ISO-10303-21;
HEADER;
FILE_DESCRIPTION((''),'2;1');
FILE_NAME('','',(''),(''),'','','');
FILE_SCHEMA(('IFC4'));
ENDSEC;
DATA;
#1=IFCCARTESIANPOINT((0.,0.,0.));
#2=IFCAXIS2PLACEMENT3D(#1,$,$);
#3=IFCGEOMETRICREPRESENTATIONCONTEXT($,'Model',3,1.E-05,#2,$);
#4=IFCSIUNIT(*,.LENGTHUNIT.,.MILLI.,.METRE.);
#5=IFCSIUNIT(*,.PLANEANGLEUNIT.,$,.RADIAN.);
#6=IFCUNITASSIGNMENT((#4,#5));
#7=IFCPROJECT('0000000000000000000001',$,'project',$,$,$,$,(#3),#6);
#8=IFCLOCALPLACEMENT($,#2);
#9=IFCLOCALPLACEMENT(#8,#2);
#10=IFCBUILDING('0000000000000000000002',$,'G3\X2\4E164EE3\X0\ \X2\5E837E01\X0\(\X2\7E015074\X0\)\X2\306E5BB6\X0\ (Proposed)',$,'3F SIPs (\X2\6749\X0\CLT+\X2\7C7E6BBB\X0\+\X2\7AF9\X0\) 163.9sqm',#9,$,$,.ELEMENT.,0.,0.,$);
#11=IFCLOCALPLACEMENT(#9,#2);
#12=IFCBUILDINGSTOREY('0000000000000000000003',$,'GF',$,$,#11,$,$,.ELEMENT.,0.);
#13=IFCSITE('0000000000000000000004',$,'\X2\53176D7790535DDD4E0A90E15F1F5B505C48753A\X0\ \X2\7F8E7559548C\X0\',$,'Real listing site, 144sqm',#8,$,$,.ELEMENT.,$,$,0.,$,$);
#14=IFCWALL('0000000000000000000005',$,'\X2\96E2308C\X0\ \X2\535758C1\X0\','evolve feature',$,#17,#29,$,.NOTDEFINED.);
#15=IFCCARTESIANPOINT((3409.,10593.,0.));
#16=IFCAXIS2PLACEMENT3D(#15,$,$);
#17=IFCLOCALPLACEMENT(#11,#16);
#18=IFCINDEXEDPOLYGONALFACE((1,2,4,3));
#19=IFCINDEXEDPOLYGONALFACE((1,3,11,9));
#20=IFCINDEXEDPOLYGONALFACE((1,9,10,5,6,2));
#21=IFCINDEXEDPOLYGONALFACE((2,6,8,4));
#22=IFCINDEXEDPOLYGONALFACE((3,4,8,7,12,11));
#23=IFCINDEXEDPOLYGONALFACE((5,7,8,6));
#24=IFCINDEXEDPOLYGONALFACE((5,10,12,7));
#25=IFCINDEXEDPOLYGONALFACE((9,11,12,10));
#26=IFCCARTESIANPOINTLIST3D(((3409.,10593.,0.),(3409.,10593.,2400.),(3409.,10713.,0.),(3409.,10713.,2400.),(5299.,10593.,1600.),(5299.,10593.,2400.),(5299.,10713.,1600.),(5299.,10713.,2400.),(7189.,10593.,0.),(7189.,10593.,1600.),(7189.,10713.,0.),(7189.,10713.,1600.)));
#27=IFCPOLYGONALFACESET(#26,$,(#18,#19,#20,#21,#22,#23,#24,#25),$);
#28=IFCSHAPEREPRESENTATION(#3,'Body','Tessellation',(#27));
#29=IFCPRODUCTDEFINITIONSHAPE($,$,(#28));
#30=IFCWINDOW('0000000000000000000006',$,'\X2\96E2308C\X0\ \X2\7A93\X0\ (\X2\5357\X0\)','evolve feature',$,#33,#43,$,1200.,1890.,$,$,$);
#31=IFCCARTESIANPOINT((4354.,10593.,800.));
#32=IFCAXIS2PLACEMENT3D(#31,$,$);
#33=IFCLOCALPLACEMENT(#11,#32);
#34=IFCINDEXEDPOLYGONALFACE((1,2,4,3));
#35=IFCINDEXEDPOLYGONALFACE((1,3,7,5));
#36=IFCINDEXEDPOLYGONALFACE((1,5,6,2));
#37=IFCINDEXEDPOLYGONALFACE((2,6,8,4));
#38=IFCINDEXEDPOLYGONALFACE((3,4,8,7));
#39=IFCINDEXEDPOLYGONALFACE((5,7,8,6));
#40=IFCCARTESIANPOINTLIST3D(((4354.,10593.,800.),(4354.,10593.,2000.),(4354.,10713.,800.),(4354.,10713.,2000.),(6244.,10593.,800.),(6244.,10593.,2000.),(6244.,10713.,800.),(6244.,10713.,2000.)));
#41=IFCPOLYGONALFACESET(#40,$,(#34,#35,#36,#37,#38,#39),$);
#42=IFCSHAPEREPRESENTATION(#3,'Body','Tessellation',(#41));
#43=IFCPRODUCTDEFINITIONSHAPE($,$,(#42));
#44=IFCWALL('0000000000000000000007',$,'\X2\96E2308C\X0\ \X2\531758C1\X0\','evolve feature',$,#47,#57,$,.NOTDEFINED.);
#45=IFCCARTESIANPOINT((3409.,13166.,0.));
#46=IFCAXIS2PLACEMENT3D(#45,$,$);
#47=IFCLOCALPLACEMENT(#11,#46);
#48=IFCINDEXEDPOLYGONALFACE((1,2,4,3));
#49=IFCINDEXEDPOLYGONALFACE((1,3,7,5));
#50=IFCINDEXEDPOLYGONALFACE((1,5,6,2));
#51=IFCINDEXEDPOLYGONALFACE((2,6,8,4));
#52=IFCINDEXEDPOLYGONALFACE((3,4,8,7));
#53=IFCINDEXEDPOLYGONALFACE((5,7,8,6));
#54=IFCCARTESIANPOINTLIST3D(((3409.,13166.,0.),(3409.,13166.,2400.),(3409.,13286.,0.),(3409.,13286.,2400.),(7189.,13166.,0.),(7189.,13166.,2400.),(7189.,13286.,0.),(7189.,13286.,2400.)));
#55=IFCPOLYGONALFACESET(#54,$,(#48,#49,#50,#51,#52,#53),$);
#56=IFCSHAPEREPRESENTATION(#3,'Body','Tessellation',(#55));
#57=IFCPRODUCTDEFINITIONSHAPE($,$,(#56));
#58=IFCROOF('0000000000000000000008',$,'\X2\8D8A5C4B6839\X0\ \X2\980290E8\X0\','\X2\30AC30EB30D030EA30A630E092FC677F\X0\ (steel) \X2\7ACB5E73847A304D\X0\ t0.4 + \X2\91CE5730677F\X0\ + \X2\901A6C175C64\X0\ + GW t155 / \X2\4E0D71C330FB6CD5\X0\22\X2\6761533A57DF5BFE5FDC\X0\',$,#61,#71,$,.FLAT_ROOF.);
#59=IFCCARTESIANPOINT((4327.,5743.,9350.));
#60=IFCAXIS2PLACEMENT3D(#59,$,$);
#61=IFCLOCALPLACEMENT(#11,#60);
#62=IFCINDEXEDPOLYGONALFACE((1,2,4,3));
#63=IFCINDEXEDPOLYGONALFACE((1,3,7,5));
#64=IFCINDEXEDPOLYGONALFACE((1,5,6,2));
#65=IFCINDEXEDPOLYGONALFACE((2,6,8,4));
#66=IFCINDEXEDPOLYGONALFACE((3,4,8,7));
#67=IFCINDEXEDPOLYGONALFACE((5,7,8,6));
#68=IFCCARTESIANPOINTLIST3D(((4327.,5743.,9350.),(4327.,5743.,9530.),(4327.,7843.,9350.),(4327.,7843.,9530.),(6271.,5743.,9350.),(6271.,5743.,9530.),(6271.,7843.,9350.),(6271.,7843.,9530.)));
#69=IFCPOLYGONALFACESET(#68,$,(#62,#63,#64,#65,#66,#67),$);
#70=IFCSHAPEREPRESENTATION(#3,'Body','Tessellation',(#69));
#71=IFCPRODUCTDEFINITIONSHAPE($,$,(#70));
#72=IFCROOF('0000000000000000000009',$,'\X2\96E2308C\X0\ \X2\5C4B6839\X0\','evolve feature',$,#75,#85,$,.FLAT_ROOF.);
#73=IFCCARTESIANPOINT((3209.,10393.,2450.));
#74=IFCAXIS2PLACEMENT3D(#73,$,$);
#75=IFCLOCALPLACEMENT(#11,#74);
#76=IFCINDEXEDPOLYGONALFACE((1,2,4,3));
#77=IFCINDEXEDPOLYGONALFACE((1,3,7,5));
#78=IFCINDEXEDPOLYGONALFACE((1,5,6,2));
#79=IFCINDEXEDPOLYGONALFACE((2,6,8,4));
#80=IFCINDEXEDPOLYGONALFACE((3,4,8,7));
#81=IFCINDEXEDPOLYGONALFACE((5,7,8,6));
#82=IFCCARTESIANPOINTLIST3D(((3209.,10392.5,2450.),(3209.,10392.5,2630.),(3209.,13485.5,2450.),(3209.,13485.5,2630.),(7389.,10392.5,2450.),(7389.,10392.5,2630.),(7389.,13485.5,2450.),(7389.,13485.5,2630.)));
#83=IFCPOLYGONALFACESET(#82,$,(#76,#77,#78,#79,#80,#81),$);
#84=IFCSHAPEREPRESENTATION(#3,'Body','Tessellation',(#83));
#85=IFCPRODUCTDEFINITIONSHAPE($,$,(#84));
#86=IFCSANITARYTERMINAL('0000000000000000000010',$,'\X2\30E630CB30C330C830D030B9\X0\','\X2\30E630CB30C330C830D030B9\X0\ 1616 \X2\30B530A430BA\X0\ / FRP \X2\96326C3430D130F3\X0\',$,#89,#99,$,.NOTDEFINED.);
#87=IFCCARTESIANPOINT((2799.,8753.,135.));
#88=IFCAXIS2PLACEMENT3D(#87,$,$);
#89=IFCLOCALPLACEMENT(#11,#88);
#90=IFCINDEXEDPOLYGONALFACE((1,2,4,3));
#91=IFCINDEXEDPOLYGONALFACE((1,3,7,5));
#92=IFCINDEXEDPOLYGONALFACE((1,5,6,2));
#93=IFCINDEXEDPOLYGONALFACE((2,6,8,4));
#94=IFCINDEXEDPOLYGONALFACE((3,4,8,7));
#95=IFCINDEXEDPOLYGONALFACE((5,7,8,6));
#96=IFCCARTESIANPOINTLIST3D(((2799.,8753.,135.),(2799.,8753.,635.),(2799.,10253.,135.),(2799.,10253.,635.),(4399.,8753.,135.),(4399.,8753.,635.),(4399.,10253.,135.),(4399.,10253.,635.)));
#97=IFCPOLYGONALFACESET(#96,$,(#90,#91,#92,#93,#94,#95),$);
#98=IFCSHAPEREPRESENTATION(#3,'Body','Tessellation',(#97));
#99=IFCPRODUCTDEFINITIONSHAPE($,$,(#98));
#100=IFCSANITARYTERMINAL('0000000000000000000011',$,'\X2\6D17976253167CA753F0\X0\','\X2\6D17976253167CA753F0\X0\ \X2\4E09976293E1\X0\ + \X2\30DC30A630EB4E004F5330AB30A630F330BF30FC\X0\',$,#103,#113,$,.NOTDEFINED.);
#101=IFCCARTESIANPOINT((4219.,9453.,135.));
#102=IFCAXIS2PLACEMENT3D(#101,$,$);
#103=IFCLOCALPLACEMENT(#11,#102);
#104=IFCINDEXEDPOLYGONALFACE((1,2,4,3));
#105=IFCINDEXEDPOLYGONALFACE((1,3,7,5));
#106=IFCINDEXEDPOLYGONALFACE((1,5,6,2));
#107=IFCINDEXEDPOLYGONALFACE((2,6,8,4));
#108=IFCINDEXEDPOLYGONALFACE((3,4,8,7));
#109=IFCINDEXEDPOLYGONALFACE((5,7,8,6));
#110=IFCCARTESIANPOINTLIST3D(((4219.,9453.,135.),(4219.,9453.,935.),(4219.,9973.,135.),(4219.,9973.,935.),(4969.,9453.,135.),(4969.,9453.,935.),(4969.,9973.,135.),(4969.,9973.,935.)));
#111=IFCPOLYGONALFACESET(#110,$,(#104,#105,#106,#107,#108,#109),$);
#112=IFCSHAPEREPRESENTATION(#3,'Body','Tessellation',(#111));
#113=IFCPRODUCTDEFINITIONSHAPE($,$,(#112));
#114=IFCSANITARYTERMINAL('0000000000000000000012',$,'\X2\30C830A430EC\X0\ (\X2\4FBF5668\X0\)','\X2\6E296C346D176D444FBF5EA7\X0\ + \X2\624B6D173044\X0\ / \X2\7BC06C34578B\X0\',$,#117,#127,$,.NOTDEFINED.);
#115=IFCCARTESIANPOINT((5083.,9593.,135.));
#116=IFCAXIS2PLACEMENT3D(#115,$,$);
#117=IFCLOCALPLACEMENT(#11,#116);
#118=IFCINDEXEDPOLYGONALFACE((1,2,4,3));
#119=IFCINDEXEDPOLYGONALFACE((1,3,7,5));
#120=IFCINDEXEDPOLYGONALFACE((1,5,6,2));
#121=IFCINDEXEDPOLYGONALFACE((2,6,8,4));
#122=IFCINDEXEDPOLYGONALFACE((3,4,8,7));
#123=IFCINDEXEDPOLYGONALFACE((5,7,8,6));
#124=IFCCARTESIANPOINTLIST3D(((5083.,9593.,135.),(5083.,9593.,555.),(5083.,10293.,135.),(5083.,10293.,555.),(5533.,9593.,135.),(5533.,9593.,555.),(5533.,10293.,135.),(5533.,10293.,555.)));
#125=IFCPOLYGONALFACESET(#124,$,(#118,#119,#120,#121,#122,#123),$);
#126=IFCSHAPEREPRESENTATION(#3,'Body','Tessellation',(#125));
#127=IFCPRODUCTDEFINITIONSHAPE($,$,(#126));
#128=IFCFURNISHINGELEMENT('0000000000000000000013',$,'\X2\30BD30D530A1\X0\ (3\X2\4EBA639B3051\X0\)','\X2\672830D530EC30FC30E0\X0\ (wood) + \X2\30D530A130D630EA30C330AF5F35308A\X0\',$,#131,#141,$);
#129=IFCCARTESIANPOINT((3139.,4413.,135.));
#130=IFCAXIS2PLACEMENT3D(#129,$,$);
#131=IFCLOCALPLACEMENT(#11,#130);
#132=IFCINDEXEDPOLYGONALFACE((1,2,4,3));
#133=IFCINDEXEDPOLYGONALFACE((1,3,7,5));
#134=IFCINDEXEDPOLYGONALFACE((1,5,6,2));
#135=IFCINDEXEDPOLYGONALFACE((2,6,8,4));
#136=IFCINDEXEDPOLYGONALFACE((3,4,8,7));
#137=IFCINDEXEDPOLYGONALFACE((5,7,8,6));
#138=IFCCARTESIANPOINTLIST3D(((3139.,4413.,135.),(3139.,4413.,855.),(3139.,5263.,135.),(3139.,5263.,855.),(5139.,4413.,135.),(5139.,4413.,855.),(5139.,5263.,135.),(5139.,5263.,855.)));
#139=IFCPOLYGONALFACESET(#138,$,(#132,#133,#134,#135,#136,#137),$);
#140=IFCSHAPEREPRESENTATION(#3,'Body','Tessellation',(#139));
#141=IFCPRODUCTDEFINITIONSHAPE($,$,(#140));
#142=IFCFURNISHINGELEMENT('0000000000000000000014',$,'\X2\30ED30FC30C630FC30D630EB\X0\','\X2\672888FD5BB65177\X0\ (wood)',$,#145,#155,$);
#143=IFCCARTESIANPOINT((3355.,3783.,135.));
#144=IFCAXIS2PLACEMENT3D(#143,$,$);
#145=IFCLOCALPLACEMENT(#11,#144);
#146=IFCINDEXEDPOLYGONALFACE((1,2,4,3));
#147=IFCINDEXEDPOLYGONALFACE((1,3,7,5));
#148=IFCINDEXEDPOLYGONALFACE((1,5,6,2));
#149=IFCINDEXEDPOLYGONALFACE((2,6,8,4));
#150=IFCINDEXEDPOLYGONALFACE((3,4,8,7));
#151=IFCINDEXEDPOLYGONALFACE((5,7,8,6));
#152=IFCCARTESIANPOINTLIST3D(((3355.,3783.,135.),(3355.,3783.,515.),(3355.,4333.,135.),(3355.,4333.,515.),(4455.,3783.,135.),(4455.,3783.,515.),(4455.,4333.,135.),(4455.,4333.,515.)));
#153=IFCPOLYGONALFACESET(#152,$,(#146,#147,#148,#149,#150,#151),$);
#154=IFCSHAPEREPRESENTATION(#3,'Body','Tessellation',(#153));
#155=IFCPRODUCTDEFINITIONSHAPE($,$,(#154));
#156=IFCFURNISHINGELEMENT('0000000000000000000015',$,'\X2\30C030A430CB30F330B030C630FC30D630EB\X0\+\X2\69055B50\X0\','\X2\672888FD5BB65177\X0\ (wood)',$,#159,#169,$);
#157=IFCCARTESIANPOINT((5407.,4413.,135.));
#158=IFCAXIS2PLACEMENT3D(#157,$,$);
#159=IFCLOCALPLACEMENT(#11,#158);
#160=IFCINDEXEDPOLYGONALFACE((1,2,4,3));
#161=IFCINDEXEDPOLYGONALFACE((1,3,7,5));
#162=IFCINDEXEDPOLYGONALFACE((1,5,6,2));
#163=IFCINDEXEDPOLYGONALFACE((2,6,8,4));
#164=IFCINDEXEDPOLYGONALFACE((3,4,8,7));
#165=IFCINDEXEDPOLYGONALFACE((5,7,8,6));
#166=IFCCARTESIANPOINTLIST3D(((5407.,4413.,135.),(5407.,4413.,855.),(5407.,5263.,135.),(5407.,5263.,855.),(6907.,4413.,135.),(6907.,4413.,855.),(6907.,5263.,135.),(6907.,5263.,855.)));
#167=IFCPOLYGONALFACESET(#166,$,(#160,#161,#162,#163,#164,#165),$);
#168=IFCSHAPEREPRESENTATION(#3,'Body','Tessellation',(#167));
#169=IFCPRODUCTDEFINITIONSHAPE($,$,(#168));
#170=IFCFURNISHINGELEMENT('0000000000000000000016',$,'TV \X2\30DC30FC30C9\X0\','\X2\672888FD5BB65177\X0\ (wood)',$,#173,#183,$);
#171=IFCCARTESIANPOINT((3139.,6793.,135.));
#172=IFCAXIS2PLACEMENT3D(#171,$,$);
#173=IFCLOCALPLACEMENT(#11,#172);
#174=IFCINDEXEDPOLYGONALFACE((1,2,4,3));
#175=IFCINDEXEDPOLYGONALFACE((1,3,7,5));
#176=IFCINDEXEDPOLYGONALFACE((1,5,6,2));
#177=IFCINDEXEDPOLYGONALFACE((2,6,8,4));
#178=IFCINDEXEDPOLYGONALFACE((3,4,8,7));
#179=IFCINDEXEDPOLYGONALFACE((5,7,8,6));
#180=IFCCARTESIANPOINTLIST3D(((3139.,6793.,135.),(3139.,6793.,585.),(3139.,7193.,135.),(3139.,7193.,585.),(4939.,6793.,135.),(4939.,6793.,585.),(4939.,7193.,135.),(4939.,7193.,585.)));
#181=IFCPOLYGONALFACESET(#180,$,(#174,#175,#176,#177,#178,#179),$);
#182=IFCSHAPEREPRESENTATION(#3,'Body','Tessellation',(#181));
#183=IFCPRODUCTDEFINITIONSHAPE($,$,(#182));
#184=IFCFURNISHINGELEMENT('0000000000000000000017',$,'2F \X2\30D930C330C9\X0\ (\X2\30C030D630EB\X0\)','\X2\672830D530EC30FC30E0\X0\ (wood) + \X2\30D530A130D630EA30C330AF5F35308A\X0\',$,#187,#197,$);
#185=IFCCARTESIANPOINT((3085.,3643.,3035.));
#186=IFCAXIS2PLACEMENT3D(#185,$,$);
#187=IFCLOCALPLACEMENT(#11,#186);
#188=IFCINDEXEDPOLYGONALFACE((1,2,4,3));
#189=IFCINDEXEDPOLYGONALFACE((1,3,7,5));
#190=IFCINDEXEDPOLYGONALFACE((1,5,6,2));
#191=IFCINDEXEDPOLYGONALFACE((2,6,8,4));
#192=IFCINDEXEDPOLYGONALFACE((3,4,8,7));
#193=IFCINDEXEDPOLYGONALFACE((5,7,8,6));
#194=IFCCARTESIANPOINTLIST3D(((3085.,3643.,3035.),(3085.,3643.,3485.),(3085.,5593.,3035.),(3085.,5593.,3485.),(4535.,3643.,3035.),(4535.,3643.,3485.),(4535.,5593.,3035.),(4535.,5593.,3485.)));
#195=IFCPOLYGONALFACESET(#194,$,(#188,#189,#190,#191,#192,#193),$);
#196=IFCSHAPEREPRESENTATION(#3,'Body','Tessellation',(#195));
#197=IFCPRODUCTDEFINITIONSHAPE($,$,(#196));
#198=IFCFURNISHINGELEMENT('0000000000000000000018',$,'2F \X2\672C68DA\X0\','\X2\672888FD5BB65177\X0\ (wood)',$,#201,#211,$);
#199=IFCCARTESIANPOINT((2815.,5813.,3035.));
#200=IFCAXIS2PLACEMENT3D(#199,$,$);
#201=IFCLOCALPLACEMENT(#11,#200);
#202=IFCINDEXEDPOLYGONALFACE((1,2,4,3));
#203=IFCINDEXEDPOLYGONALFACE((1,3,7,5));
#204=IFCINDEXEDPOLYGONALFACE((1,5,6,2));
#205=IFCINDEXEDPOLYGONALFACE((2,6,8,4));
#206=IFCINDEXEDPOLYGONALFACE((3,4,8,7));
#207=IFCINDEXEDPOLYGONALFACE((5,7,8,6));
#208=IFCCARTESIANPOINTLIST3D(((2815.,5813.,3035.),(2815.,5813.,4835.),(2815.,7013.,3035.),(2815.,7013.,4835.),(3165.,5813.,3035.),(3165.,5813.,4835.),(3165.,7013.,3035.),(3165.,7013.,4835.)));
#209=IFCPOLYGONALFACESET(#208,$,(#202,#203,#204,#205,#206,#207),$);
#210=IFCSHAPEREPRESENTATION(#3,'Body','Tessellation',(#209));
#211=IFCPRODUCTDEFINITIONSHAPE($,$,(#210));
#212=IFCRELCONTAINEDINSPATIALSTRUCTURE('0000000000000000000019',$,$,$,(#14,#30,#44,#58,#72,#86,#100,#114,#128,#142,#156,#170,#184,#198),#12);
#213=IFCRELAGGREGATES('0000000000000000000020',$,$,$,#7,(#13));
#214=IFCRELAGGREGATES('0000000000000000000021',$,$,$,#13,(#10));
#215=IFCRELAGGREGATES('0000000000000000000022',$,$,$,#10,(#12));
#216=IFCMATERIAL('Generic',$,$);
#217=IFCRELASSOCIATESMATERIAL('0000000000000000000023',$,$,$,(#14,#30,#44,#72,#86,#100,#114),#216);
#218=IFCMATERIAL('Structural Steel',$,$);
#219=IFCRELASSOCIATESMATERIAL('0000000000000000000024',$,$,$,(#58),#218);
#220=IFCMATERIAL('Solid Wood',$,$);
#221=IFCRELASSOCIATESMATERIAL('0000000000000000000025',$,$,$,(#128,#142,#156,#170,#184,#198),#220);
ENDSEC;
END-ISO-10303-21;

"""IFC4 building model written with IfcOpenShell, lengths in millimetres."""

from ifc_helpers import new_model, si_unit, frame, frame_2d, origin, place, context, project, spatial, rectangle, extrude, material, element, fill, save


model = new_model("IFC4")

# Units and contexts
model_context = context("Model", 3, precision=1e-05, world=origin())
ifc_project = project(units=[si_unit("LENGTHUNIT", "METRE", prefix="MILLI"), si_unit("PLANEANGLEUNIT", "RADIAN")], contexts=[model_context])

# Site, building, storey
site_placement = place(None, origin())
site = spatial("IfcSite", under=ifc_project, at=site_placement, Name="北海道川上郡弟子屈町 美留和", ObjectType="Real listing site, 144sqm", CompositionType="ELEMENT", RefElevation=0.0)
building_placement = place(site_placement, origin())
building = spatial("IfcBuilding", under=site, at=building_placement, Name="G3世代 広縁(縁側)の家 (Proposed)", ObjectType="3F SIPs (杉CLT+籾殻+竹) 163.9sqm", CompositionType="ELEMENT", ElevationOfRefHeight=0.0, ElevationOfTerrain=0.0)
storey_placement = place(building_placement, origin())
storey = spatial("IfcBuildingStorey", under=building, at=storey_placement, Name="GF", CompositionType="ELEMENT", Elevation=0.0)

# Shared definitions
ifc_material_1 = material(Name="Generic")

# Shared definitions
ifc_material_2 = material(Name="Solid Wood")

# Wall, opening, window
wall_1_placement = place(storey_placement, frame((3409.0, 10593.0, 0.0)))
wall_1 = element("IfcWall", 1, at=wall_1_placement, inside=storey, material=ifc_material_1, Name="離れ 南壁", Description="evolve feature", PredefinedType="NOTDEFINED", context=model_context, shape_type="SweptSolid", body=[
    extrude(rectangle(XDim=3780.0, YDim=120.0, at=frame_2d((1890.0, 60.0))), frame((3409.0, 10593.0, 0.0)), (0.0, 0.0, 1.0), 2400.0),
])
opening_1_placement = place(storey_placement, frame((4354.0, 10593.0, 800.0)))
opening_1 = element("IfcOpeningElement", 2, at=opening_1_placement, cuts=wall_1, PredefinedType="NOTDEFINED", context=model_context, shape_type="SweptSolid", body=[
    extrude(rectangle(XDim=1890.0, YDim=120.0, at=frame_2d((945.0, 60.0))), frame((4354.0, 10593.0, 800.0)), (0.0, 0.0, 1.0), 1200.0),
])
window_1_placement = place(storey_placement, frame((4354.0, 10593.0, 800.0)))
window_1 = element("IfcWindow", 3, at=window_1_placement, inside=storey, material=ifc_material_1, Name="離れ 窓 (南)", Description="evolve feature", OverallHeight=1200.0, OverallWidth=1890.0, context=model_context, shape_type="SweptSolid", body=[
    extrude(rectangle(XDim=1890.0, YDim=120.0, at=frame_2d((945.0, 60.0))), frame((4354.0, 10593.0, 800.0)), (0.0, 0.0, 1.0), 1200.0),
])
fill(opening_1, window_1)

# Wall
wall_2_placement = place(storey_placement, frame((3409.0, 13166.0, 0.0)))
element("IfcWall", 4, at=wall_2_placement, inside=storey, material=ifc_material_1, Name="離れ 北壁", Description="evolve feature", PredefinedType="NOTDEFINED", context=model_context, shape_type="SweptSolid", body=[
    extrude(rectangle(XDim=3780.0, YDim=120.0, at=frame_2d((1890.0, 60.0))), frame((3409.0, 13166.0, 0.0)), (0.0, 0.0, 1.0), 2400.0),
])

# Roofs
ifc_material_3 = material(Name="Structural Steel")
roof_1_placement = place(storey_placement, frame((4327.0, 5743.0, 9350.0)))
element("IfcRoof", 5, at=roof_1_placement, inside=storey, material=ifc_material_3, Name="越屋根 頂部", Description="ガルバリウム鋼板 (steel) 立平葺き t0.4 + 野地板 + 通気層 + GW t155 / 不燃・法22条区域対応", PredefinedType="FLAT_ROOF", context=model_context, shape_type="SweptSolid", body=[
    extrude(rectangle(XDim=1944.0, YDim=2100.0, at=frame_2d((972.0, 1050.0))), frame((4327.0, 5743.0, 9350.0)), (0.0, 0.0, 1.0), 180.0),
])
roof_2_placement = place(storey_placement, frame((3209.0, 10393.0, 2450.0)))
element("IfcRoof", 6, at=roof_2_placement, inside=storey, material=ifc_material_1, Name="離れ 屋根", Description="evolve feature", PredefinedType="FLAT_ROOF", context=model_context, shape_type="SweptSolid", body=[
    extrude(rectangle(XDim=4180.0, YDim=3093.0, at=frame_2d((2090.0, 1546.0))), frame((3209.0, 10393.0, 2450.0)), (0.0, 0.0, 1.0), 180.0),
])

# Sanitary terminals
sanitary_terminal_1_placement = place(storey_placement, frame((2799.0, 8753.0, 135.0)))
element("IfcSanitaryTerminal", 7, at=sanitary_terminal_1_placement, inside=storey, material=ifc_material_1, Name="ユニットバス", Description="ユニットバス 1616 サイズ / FRP 防水パン", PredefinedType="NOTDEFINED", context=model_context, shape_type="SweptSolid", body=[
    extrude(rectangle(XDim=1600.0, YDim=1500.0, at=frame_2d((800.0, 750.0))), frame((2799.0, 8753.0, 135.0)), (0.0, 0.0, 1.0), 500.0),
])
sanitary_terminal_2_placement = place(storey_placement, frame((4219.0, 9453.0, 135.0)))
element("IfcSanitaryTerminal", 8, at=sanitary_terminal_2_placement, inside=storey, material=ifc_material_1, Name="洗面化粧台", Description="洗面化粧台 三面鏡 + ボウル一体カウンター", PredefinedType="NOTDEFINED", context=model_context, shape_type="SweptSolid", body=[
    extrude(rectangle(XDim=750.0, YDim=520.0, at=frame_2d((375.0, 260.0))), frame((4219.0, 9453.0, 135.0)), (0.0, 0.0, 1.0), 800.0),
])
sanitary_terminal_3_placement = place(storey_placement, frame((5083.0, 9593.0, 135.0)))
element("IfcSanitaryTerminal", 9, at=sanitary_terminal_3_placement, inside=storey, material=ifc_material_1, Name="トイレ (便器)", Description="温水洗浄便座 + 手洗い / 節水型", PredefinedType="NOTDEFINED", context=model_context, shape_type="SweptSolid", body=[
    extrude(rectangle(XDim=450.0, YDim=700.0, at=frame_2d((225.0, 350.0))), frame((5083.0, 9593.0, 135.0)), (0.0, 0.0, 1.0), 420.0),
])

# Furnishing elements
furnishing_1_placement = place(storey_placement, frame((3139.0, 4413.0, 135.0)))
element("IfcFurnishingElement", 10, at=furnishing_1_placement, inside=storey, material=ifc_material_2, Name="ソファ (3人掛け)", Description="木フレーム (wood) + ファブリック張り", context=model_context, shape_type="SweptSolid", body=[
    extrude(rectangle(XDim=2000.0, YDim=850.0, at=frame_2d((1000.0, 425.0))), frame((3139.0, 4413.0, 135.0)), (0.0, 0.0, 1.0), 720.0),
])
furnishing_2_placement = place(storey_placement, frame((3355.0, 3783.0, 135.0)))
element("IfcFurnishingElement", 11, at=furnishing_2_placement, inside=storey, material=ifc_material_2, Name="ローテーブル", Description="木製家具 (wood)", context=model_context, shape_type="SweptSolid", body=[
    extrude(rectangle(XDim=1100.0, YDim=550.0, at=frame_2d((550.0, 275.0))), frame((3355.0, 3783.0, 135.0)), (0.0, 0.0, 1.0), 380.0),
])
furnishing_3_placement = place(storey_placement, frame((5407.0, 4413.0, 135.0)))
element("IfcFurnishingElement", 12, at=furnishing_3_placement, inside=storey, material=ifc_material_2, Name="ダイニングテーブル+椅子", Description="木製家具 (wood)", context=model_context, shape_type="SweptSolid", body=[
    extrude(rectangle(XDim=1500.0, YDim=850.0, at=frame_2d((750.0, 425.0))), frame((5407.0, 4413.0, 135.0)), (0.0, 0.0, 1.0), 720.0),
])
furnishing_4_placement = place(storey_placement, frame((3139.0, 6793.0, 135.0)))
element("IfcFurnishingElement", 13, at=furnishing_4_placement, inside=storey, material=ifc_material_2, Name="TV ボード", Description="木製家具 (wood)", context=model_context, shape_type="SweptSolid", body=[
    extrude(rectangle(XDim=1800.0, YDim=400.0, at=frame_2d((900.0, 200.0))), frame((3139.0, 6793.0, 135.0)), (0.0, 0.0, 1.0), 450.0),
])
furnishing_5_placement = place(storey_placement, frame((3085.0, 3643.0, 3035.0)))
element("IfcFurnishingElement", 14, at=furnishing_5_placement, inside=storey, material=ifc_material_2, Name="2F ベッド (ダブル)", Description="木フレーム (wood) + ファブリック張り", context=model_context, shape_type="SweptSolid", body=[
    extrude(rectangle(XDim=1450.0, YDim=1950.0, at=frame_2d((725.0, 975.0))), frame((3085.0, 3643.0, 3035.0)), (0.0, 0.0, 1.0), 450.0),
])
furnishing_6_placement = place(storey_placement, frame((2815.0, 5813.0, 3035.0)))
element("IfcFurnishingElement", 15, at=furnishing_6_placement, inside=storey, material=ifc_material_2, Name="2F 本棚", Description="木製家具 (wood)", context=model_context, shape_type="SweptSolid", body=[
    extrude(rectangle(XDim=350.0, YDim=1200.0, at=frame_2d((175.0, 600.0))), frame((2815.0, 5813.0, 3035.0)), (0.0, 0.0, 1.0), 1800.0),
])

save(model, "model.ifc")
